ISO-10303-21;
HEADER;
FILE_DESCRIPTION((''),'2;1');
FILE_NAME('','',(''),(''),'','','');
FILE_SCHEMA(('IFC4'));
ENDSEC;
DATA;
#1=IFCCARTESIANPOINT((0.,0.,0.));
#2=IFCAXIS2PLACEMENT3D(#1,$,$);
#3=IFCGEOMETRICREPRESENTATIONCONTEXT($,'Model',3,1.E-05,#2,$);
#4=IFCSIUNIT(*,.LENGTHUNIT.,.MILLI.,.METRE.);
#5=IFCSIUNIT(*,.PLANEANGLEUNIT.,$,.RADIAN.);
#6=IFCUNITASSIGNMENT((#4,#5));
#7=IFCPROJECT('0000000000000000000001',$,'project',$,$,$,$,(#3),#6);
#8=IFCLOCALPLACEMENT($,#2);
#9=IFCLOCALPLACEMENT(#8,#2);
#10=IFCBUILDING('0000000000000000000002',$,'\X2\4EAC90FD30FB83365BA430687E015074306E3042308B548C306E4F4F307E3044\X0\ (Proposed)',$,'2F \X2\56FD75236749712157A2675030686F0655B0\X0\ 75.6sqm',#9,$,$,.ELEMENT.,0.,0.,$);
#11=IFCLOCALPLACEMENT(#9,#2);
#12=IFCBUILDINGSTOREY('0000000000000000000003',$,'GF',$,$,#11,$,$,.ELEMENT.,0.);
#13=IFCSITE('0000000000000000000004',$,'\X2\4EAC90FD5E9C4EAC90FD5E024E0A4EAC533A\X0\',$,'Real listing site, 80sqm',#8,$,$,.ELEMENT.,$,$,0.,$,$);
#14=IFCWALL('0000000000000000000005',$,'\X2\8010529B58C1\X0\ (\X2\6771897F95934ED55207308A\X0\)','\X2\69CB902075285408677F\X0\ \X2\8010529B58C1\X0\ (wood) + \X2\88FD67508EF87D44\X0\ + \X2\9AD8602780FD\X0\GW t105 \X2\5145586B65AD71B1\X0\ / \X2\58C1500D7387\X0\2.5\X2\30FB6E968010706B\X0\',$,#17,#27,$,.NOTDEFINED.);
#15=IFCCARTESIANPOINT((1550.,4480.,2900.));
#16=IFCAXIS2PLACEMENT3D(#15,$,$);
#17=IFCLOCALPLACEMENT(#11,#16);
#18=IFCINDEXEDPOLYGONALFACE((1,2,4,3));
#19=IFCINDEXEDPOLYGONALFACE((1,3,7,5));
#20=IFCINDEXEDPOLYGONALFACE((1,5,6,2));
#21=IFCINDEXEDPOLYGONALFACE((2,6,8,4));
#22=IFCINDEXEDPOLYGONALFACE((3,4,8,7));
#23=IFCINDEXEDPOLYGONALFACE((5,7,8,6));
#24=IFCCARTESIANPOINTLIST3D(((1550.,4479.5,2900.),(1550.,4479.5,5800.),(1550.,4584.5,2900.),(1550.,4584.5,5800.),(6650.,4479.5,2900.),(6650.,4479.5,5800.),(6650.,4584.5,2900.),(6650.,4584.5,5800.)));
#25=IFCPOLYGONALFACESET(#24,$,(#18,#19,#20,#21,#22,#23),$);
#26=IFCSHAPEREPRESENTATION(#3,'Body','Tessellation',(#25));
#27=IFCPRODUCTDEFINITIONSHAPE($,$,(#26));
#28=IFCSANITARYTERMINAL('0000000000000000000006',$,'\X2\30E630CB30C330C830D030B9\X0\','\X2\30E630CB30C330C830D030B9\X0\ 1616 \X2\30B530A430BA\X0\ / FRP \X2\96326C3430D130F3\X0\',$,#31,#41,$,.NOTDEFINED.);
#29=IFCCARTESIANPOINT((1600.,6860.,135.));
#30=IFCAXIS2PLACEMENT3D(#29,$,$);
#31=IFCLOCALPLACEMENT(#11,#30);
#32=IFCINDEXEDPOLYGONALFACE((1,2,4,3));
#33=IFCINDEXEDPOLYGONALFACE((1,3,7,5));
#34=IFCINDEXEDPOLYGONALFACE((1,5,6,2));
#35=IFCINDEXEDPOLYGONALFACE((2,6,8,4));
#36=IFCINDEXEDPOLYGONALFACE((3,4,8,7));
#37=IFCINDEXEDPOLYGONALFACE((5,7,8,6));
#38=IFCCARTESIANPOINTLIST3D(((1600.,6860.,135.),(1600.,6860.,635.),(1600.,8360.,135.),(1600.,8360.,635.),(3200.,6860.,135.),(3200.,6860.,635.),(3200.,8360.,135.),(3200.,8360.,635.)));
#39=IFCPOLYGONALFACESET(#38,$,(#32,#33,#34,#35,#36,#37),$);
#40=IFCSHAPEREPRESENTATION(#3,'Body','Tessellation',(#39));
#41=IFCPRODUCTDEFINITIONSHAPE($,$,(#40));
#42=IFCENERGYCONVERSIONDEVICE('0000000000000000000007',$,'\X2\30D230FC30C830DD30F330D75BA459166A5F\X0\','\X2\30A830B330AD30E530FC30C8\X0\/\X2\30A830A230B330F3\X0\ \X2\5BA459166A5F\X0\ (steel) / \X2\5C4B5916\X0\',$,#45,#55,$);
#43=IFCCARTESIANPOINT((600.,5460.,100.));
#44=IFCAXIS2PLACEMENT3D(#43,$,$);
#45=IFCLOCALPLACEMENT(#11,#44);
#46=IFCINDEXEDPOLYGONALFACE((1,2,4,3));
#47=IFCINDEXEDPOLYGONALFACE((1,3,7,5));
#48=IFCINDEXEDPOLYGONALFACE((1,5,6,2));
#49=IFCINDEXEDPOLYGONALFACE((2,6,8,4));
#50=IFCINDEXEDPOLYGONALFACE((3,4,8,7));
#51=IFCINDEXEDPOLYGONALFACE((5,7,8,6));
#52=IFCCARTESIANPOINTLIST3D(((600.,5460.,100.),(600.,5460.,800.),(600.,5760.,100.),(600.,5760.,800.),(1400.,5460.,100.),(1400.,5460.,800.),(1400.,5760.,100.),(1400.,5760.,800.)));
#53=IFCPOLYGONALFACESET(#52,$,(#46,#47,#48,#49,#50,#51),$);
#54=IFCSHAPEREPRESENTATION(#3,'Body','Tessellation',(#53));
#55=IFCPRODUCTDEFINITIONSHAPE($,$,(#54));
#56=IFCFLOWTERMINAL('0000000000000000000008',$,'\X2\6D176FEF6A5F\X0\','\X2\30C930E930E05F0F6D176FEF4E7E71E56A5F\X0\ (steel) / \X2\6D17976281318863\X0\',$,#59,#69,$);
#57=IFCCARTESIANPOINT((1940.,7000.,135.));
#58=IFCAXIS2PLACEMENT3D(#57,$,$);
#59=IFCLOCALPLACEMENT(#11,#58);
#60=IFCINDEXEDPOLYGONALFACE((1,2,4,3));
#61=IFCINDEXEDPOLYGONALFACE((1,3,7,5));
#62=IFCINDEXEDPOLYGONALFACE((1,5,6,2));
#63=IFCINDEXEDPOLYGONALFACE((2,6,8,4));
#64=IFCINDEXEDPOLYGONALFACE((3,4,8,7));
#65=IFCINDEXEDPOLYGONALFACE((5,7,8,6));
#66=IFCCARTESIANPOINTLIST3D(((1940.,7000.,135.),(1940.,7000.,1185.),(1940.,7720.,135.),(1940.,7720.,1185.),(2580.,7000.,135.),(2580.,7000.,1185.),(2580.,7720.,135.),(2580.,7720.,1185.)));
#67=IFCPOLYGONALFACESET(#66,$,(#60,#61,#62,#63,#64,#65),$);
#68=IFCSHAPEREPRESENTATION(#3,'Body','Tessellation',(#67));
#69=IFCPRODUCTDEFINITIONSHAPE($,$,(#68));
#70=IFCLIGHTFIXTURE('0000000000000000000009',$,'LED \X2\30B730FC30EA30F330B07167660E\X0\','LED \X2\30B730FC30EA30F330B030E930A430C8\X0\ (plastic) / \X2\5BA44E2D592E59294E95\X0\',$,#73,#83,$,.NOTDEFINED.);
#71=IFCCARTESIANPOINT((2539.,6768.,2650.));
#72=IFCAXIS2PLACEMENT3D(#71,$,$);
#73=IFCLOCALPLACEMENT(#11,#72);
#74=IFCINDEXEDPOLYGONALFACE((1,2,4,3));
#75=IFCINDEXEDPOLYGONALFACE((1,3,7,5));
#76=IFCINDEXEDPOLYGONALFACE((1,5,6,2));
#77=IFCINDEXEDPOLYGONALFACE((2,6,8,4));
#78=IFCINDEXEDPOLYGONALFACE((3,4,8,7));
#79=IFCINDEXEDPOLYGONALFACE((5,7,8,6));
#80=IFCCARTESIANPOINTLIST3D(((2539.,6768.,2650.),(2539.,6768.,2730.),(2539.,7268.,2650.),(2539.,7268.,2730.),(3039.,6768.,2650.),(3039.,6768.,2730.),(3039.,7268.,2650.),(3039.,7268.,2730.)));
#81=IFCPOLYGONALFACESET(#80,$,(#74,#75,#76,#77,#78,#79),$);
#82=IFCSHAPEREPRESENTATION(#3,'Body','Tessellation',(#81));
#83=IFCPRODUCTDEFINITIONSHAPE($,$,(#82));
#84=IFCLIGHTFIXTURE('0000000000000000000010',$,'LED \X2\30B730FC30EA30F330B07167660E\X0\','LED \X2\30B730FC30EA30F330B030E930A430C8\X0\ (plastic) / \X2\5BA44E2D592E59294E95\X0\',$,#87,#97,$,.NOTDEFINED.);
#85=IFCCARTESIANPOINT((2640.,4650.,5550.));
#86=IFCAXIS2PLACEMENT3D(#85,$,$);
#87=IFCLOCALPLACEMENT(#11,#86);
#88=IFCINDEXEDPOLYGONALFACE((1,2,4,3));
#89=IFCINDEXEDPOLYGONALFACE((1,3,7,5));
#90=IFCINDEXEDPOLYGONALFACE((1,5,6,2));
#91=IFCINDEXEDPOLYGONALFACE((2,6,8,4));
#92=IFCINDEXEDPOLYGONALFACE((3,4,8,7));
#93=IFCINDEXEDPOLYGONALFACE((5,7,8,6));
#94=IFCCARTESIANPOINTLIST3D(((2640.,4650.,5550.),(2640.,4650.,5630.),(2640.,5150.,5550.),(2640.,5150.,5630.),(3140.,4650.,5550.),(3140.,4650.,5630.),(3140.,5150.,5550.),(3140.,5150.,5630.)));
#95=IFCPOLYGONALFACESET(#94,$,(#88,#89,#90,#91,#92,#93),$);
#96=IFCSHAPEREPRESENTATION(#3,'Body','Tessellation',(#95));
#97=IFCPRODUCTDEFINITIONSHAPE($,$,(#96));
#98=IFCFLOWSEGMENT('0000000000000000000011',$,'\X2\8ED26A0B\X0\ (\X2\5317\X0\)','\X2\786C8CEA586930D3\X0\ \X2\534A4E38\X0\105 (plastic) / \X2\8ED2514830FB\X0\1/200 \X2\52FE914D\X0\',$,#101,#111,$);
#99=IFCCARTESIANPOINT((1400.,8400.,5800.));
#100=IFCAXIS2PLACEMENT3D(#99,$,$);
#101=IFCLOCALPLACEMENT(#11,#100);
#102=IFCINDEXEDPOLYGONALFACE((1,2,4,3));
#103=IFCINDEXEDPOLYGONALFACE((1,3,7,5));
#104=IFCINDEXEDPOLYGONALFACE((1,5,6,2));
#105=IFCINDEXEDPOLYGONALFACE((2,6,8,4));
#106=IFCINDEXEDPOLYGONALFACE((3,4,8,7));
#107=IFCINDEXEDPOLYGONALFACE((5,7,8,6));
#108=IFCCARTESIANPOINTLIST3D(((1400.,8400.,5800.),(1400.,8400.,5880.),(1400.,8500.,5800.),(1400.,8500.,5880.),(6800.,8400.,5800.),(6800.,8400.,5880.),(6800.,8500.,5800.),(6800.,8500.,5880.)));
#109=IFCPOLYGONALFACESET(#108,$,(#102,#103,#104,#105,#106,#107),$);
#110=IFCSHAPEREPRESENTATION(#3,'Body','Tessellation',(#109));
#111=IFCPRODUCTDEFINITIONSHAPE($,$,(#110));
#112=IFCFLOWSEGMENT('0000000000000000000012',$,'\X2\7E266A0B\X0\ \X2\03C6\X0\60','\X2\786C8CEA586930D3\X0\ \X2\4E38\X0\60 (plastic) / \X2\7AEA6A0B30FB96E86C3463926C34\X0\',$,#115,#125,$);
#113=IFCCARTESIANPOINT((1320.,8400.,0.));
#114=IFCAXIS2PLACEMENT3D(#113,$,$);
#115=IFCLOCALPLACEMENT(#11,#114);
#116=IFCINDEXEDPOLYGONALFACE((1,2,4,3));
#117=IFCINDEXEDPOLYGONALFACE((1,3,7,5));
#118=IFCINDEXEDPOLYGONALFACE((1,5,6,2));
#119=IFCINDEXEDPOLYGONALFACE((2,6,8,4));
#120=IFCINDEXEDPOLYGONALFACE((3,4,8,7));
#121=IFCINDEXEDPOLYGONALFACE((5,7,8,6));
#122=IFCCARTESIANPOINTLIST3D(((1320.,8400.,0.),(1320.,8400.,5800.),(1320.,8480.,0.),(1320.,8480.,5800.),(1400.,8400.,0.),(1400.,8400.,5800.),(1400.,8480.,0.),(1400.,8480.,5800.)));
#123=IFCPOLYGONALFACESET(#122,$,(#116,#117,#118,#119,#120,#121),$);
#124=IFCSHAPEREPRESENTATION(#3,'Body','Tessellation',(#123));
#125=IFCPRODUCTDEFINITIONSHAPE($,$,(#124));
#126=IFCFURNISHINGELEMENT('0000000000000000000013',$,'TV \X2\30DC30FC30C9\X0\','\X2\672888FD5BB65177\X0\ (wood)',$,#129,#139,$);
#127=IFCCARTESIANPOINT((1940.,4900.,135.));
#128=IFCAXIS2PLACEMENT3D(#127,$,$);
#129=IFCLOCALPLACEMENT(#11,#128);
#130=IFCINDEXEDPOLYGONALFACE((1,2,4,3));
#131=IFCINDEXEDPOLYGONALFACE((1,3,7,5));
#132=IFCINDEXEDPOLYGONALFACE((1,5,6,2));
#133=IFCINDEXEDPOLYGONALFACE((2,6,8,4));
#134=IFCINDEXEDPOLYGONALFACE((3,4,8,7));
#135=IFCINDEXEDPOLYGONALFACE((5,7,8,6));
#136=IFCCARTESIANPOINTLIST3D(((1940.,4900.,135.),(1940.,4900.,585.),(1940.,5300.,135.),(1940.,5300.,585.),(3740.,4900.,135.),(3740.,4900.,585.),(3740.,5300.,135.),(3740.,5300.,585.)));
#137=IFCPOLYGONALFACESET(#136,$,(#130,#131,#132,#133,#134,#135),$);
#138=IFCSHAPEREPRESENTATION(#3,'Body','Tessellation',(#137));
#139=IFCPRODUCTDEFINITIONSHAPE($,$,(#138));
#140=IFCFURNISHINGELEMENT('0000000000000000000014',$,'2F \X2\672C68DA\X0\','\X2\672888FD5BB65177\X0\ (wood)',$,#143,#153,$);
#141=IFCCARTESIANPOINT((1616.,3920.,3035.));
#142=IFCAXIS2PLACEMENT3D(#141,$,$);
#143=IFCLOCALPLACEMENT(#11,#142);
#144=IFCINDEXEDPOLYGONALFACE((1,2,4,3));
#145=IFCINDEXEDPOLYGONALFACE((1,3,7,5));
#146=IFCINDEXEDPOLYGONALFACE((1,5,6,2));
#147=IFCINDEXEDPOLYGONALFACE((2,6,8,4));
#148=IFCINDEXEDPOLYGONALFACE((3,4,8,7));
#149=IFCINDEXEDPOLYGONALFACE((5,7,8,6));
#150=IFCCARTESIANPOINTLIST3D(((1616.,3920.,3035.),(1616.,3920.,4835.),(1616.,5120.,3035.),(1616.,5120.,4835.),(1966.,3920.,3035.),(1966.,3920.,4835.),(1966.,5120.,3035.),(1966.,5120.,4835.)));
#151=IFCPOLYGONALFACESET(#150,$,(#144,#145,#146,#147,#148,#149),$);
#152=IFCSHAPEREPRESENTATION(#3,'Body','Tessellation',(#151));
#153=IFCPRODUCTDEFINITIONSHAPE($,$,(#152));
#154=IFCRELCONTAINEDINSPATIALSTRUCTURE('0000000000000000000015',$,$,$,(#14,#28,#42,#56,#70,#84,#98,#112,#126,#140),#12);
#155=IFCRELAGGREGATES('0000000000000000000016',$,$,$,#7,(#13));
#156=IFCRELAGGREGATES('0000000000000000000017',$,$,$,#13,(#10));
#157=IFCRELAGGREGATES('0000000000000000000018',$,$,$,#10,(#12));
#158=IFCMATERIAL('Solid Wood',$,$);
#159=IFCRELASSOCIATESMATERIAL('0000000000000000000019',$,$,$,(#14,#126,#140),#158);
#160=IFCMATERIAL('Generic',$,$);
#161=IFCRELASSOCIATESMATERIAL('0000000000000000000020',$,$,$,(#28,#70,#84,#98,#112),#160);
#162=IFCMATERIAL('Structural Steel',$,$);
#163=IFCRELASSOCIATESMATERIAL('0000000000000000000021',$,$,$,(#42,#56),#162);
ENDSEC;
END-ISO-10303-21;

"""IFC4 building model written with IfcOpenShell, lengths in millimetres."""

from ifc_helpers import new_model, si_unit, frame, frame_2d, origin, place, context, project, spatial, rectangle, extrude, material, element, save


model = new_model("IFC4")

# Units and contexts
model_context = context("Model", 3, precision=1e-05, world=origin())
ifc_project = project(units=[si_unit("LENGTHUNIT", "METRE", prefix="MILLI"), si_unit("PLANEANGLEUNIT", "RADIAN")], contexts=[model_context])

# Site, building, storey
site_placement = place(None, origin())
site = spatial("IfcSite", under=ifc_project, at=site_placement, Name="京都府京都市上京区", ObjectType="Real listing site, 80sqm", CompositionType="ELEMENT", RefElevation=0.0)
building_placement = place(site_placement, origin())
building = spatial("IfcBuilding", under=site, at=building_placement, Name="京都・茶室と縁側のある和の住まい (Proposed)", ObjectType="2F 国産杉無垢材と漆喰 75.6sqm", CompositionType="ELEMENT", ElevationOfRefHeight=0.0, ElevationOfTerrain=0.0)
storey_placement = place(building_placement, origin())
storey = spatial("IfcBuildingStorey", under=building, at=storey_placement, Name="GF", CompositionType="ELEMENT", Elevation=0.0)

# Shared definitions
ifc_material_1 = material(Name="Solid Wood")

# Wall
wall_1_placement = place(storey_placement, frame((1550.0, 4480.0, 2900.0)))
element("IfcWall", 1, at=wall_1_placement, inside=storey, material=ifc_material_1, Name="耐力壁 (東西間仕切り)", Description="構造用合板 耐力壁 (wood) + 製材軸組 + 高性能GW t105 充填断熱 / 壁倍率2.5・準耐火", PredefinedType="NOTDEFINED", context=model_context, shape_type="SweptSolid", body=[
    extrude(rectangle(XDim=5100.0, YDim=105.0, at=frame_2d((2550.0, 52.0))), frame((1550.0, 4480.0, 2900.0)), (0.0, 0.0, 1.0), 2900.0),
])

# Sanitary terminal
ifc_material_2 = material(Name="Generic")
sanitary_terminal_placement = place(storey_placement, frame((1600.0, 6860.0, 135.0)))
element("IfcSanitaryTerminal", 2, at=sanitary_terminal_placement, inside=storey, material=ifc_material_2, Name="ユニットバス", Description="ユニットバス 1616 サイズ / FRP 防水パン", PredefinedType="NOTDEFINED", context=model_context, shape_type="SweptSolid", body=[
    extrude(rectangle(XDim=1600.0, YDim=1500.0, at=frame_2d((800.0, 750.0))), frame((1600.0, 6860.0, 135.0)), (0.0, 0.0, 1.0), 500.0),
])

# Shared definitions
ifc_material_3 = material(Name="Structural Steel")

# Energy conversion device
energy_conversion_device_placement = place(storey_placement, frame((600.0, 5460.0, 100.0)))
element("IfcEnergyConversionDevice", 3, at=energy_conversion_device_placement, inside=storey, material=ifc_material_3, Name="ヒートポンプ室外機", Description="エコキュート/エアコン 室外機 (steel) / 屋外", context=model_context, shape_type="SweptSolid", body=[
    extrude(rectangle(XDim=800.0, YDim=300.0, at=frame_2d((400.0, 150.0))), frame((600.0, 5460.0, 100.0)), (0.0, 0.0, 1.0), 700.0),
])

# Flow terminal
flow_terminal_placement = place(storey_placement, frame((1940.0, 7000.0, 135.0)))
element("IfcFlowTerminal", 4, at=flow_terminal_placement, inside=storey, material=ifc_material_3, Name="洗濯機", Description="ドラム式洗濯乾燥機 (steel) / 洗面脱衣", context=model_context, shape_type="SweptSolid", body=[
    extrude(rectangle(XDim=640.0, YDim=720.0, at=frame_2d((320.0, 360.0))), frame((1940.0, 7000.0, 135.0)), (0.0, 0.0, 1.0), 1050.0),
])

# Light fixtures
light_fixture_1_placement = place(storey_placement, frame((2539.0, 6768.0, 2650.0)))
element("IfcLightFixture", 5, at=light_fixture_1_placement, inside=storey, material=ifc_material_2, Name="LED シーリング照明", Description="LED シーリングライト (plastic) / 室中央天井", PredefinedType="NOTDEFINED", context=model_context, shape_type="SweptSolid", body=[
    extrude(rectangle(XDim=500.0, YDim=500.0, at=frame_2d((250.0, 250.0))), frame((2539.0, 6768.0, 2650.0)), (0.0, 0.0, 1.0), 80.0),
])
light_fixture_2_placement = place(storey_placement, frame((2640.0, 4650.0, 5550.0)))
element("IfcLightFixture", 6, at=light_fixture_2_placement, inside=storey, material=ifc_material_2, Name="LED シーリング照明", Description="LED シーリングライト (plastic) / 室中央天井", PredefinedType="NOTDEFINED", context=model_context, shape_type="SweptSolid", body=[
    extrude(rectangle(XDim=500.0, YDim=500.0, at=frame_2d((250.0, 250.0))), frame((2640.0, 4650.0, 5550.0)), (0.0, 0.0, 1.0), 80.0),
])

# Flow segments
flow_segment_1_placement = place(storey_placement, frame((1400.0, 8400.0, 5800.0)))
element("IfcFlowSegment", 7, at=flow_segment_1_placement, inside=storey, material=ifc_material_2, Name="軒樋 (北)", Description="硬質塩ビ 半丸105 (plastic) / 軒先・1/200 勾配", context=model_context, shape_type="SweptSolid", body=[
    extrude(rectangle(XDim=5400.0, YDim=100.0, at=frame_2d((2700.0, 50.0))), frame((1400.0, 8400.0, 5800.0)), (0.0, 0.0, 1.0), 80.0),
])
flow_segment_2_placement = place(storey_placement, frame((1320.0, 8400.0, 0.0)))
element("IfcFlowSegment", 8, at=flow_segment_2_placement, inside=storey, material=ifc_material_2, Name="縦樋 φ60", Description="硬質塩ビ 丸60 (plastic) / 竪樋・雨水排水", context=model_context, shape_type="SweptSolid", body=[
    extrude(rectangle(XDim=80.0, YDim=80.0, at=frame_2d((40.0, 40.0))), frame((1320.0, 8400.0, 0.0)), (0.0, 0.0, 1.0), 5800.0),
])

# Furnishing elements
furnishing_1_placement = place(storey_placement, frame((1940.0, 4900.0, 135.0)))
element("IfcFurnishingElement", 9, at=furnishing_1_placement, inside=storey, material=ifc_material_1, Name="TV ボード", Description="木製家具 (wood)", context=model_context, shape_type="SweptSolid", body=[
    extrude(rectangle(XDim=1800.0, YDim=400.0, at=frame_2d((900.0, 200.0))), frame((1940.0, 4900.0, 135.0)), (0.0, 0.0, 1.0), 450.0),
])
furnishing_2_placement = place(storey_placement, frame((1616.0, 3920.0, 3035.0)))
element("IfcFurnishingElement", 10, at=furnishing_2_placement, inside=storey, material=ifc_material_1, Name="2F 本棚", Description="木製家具 (wood)", context=model_context, shape_type="SweptSolid", body=[
    extrude(rectangle(XDim=350.0, YDim=1200.0, at=frame_2d((175.0, 600.0))), frame((1616.0, 3920.0, 3035.0)), (0.0, 0.0, 1.0), 1800.0),
])

save(model, "model.ifc")
